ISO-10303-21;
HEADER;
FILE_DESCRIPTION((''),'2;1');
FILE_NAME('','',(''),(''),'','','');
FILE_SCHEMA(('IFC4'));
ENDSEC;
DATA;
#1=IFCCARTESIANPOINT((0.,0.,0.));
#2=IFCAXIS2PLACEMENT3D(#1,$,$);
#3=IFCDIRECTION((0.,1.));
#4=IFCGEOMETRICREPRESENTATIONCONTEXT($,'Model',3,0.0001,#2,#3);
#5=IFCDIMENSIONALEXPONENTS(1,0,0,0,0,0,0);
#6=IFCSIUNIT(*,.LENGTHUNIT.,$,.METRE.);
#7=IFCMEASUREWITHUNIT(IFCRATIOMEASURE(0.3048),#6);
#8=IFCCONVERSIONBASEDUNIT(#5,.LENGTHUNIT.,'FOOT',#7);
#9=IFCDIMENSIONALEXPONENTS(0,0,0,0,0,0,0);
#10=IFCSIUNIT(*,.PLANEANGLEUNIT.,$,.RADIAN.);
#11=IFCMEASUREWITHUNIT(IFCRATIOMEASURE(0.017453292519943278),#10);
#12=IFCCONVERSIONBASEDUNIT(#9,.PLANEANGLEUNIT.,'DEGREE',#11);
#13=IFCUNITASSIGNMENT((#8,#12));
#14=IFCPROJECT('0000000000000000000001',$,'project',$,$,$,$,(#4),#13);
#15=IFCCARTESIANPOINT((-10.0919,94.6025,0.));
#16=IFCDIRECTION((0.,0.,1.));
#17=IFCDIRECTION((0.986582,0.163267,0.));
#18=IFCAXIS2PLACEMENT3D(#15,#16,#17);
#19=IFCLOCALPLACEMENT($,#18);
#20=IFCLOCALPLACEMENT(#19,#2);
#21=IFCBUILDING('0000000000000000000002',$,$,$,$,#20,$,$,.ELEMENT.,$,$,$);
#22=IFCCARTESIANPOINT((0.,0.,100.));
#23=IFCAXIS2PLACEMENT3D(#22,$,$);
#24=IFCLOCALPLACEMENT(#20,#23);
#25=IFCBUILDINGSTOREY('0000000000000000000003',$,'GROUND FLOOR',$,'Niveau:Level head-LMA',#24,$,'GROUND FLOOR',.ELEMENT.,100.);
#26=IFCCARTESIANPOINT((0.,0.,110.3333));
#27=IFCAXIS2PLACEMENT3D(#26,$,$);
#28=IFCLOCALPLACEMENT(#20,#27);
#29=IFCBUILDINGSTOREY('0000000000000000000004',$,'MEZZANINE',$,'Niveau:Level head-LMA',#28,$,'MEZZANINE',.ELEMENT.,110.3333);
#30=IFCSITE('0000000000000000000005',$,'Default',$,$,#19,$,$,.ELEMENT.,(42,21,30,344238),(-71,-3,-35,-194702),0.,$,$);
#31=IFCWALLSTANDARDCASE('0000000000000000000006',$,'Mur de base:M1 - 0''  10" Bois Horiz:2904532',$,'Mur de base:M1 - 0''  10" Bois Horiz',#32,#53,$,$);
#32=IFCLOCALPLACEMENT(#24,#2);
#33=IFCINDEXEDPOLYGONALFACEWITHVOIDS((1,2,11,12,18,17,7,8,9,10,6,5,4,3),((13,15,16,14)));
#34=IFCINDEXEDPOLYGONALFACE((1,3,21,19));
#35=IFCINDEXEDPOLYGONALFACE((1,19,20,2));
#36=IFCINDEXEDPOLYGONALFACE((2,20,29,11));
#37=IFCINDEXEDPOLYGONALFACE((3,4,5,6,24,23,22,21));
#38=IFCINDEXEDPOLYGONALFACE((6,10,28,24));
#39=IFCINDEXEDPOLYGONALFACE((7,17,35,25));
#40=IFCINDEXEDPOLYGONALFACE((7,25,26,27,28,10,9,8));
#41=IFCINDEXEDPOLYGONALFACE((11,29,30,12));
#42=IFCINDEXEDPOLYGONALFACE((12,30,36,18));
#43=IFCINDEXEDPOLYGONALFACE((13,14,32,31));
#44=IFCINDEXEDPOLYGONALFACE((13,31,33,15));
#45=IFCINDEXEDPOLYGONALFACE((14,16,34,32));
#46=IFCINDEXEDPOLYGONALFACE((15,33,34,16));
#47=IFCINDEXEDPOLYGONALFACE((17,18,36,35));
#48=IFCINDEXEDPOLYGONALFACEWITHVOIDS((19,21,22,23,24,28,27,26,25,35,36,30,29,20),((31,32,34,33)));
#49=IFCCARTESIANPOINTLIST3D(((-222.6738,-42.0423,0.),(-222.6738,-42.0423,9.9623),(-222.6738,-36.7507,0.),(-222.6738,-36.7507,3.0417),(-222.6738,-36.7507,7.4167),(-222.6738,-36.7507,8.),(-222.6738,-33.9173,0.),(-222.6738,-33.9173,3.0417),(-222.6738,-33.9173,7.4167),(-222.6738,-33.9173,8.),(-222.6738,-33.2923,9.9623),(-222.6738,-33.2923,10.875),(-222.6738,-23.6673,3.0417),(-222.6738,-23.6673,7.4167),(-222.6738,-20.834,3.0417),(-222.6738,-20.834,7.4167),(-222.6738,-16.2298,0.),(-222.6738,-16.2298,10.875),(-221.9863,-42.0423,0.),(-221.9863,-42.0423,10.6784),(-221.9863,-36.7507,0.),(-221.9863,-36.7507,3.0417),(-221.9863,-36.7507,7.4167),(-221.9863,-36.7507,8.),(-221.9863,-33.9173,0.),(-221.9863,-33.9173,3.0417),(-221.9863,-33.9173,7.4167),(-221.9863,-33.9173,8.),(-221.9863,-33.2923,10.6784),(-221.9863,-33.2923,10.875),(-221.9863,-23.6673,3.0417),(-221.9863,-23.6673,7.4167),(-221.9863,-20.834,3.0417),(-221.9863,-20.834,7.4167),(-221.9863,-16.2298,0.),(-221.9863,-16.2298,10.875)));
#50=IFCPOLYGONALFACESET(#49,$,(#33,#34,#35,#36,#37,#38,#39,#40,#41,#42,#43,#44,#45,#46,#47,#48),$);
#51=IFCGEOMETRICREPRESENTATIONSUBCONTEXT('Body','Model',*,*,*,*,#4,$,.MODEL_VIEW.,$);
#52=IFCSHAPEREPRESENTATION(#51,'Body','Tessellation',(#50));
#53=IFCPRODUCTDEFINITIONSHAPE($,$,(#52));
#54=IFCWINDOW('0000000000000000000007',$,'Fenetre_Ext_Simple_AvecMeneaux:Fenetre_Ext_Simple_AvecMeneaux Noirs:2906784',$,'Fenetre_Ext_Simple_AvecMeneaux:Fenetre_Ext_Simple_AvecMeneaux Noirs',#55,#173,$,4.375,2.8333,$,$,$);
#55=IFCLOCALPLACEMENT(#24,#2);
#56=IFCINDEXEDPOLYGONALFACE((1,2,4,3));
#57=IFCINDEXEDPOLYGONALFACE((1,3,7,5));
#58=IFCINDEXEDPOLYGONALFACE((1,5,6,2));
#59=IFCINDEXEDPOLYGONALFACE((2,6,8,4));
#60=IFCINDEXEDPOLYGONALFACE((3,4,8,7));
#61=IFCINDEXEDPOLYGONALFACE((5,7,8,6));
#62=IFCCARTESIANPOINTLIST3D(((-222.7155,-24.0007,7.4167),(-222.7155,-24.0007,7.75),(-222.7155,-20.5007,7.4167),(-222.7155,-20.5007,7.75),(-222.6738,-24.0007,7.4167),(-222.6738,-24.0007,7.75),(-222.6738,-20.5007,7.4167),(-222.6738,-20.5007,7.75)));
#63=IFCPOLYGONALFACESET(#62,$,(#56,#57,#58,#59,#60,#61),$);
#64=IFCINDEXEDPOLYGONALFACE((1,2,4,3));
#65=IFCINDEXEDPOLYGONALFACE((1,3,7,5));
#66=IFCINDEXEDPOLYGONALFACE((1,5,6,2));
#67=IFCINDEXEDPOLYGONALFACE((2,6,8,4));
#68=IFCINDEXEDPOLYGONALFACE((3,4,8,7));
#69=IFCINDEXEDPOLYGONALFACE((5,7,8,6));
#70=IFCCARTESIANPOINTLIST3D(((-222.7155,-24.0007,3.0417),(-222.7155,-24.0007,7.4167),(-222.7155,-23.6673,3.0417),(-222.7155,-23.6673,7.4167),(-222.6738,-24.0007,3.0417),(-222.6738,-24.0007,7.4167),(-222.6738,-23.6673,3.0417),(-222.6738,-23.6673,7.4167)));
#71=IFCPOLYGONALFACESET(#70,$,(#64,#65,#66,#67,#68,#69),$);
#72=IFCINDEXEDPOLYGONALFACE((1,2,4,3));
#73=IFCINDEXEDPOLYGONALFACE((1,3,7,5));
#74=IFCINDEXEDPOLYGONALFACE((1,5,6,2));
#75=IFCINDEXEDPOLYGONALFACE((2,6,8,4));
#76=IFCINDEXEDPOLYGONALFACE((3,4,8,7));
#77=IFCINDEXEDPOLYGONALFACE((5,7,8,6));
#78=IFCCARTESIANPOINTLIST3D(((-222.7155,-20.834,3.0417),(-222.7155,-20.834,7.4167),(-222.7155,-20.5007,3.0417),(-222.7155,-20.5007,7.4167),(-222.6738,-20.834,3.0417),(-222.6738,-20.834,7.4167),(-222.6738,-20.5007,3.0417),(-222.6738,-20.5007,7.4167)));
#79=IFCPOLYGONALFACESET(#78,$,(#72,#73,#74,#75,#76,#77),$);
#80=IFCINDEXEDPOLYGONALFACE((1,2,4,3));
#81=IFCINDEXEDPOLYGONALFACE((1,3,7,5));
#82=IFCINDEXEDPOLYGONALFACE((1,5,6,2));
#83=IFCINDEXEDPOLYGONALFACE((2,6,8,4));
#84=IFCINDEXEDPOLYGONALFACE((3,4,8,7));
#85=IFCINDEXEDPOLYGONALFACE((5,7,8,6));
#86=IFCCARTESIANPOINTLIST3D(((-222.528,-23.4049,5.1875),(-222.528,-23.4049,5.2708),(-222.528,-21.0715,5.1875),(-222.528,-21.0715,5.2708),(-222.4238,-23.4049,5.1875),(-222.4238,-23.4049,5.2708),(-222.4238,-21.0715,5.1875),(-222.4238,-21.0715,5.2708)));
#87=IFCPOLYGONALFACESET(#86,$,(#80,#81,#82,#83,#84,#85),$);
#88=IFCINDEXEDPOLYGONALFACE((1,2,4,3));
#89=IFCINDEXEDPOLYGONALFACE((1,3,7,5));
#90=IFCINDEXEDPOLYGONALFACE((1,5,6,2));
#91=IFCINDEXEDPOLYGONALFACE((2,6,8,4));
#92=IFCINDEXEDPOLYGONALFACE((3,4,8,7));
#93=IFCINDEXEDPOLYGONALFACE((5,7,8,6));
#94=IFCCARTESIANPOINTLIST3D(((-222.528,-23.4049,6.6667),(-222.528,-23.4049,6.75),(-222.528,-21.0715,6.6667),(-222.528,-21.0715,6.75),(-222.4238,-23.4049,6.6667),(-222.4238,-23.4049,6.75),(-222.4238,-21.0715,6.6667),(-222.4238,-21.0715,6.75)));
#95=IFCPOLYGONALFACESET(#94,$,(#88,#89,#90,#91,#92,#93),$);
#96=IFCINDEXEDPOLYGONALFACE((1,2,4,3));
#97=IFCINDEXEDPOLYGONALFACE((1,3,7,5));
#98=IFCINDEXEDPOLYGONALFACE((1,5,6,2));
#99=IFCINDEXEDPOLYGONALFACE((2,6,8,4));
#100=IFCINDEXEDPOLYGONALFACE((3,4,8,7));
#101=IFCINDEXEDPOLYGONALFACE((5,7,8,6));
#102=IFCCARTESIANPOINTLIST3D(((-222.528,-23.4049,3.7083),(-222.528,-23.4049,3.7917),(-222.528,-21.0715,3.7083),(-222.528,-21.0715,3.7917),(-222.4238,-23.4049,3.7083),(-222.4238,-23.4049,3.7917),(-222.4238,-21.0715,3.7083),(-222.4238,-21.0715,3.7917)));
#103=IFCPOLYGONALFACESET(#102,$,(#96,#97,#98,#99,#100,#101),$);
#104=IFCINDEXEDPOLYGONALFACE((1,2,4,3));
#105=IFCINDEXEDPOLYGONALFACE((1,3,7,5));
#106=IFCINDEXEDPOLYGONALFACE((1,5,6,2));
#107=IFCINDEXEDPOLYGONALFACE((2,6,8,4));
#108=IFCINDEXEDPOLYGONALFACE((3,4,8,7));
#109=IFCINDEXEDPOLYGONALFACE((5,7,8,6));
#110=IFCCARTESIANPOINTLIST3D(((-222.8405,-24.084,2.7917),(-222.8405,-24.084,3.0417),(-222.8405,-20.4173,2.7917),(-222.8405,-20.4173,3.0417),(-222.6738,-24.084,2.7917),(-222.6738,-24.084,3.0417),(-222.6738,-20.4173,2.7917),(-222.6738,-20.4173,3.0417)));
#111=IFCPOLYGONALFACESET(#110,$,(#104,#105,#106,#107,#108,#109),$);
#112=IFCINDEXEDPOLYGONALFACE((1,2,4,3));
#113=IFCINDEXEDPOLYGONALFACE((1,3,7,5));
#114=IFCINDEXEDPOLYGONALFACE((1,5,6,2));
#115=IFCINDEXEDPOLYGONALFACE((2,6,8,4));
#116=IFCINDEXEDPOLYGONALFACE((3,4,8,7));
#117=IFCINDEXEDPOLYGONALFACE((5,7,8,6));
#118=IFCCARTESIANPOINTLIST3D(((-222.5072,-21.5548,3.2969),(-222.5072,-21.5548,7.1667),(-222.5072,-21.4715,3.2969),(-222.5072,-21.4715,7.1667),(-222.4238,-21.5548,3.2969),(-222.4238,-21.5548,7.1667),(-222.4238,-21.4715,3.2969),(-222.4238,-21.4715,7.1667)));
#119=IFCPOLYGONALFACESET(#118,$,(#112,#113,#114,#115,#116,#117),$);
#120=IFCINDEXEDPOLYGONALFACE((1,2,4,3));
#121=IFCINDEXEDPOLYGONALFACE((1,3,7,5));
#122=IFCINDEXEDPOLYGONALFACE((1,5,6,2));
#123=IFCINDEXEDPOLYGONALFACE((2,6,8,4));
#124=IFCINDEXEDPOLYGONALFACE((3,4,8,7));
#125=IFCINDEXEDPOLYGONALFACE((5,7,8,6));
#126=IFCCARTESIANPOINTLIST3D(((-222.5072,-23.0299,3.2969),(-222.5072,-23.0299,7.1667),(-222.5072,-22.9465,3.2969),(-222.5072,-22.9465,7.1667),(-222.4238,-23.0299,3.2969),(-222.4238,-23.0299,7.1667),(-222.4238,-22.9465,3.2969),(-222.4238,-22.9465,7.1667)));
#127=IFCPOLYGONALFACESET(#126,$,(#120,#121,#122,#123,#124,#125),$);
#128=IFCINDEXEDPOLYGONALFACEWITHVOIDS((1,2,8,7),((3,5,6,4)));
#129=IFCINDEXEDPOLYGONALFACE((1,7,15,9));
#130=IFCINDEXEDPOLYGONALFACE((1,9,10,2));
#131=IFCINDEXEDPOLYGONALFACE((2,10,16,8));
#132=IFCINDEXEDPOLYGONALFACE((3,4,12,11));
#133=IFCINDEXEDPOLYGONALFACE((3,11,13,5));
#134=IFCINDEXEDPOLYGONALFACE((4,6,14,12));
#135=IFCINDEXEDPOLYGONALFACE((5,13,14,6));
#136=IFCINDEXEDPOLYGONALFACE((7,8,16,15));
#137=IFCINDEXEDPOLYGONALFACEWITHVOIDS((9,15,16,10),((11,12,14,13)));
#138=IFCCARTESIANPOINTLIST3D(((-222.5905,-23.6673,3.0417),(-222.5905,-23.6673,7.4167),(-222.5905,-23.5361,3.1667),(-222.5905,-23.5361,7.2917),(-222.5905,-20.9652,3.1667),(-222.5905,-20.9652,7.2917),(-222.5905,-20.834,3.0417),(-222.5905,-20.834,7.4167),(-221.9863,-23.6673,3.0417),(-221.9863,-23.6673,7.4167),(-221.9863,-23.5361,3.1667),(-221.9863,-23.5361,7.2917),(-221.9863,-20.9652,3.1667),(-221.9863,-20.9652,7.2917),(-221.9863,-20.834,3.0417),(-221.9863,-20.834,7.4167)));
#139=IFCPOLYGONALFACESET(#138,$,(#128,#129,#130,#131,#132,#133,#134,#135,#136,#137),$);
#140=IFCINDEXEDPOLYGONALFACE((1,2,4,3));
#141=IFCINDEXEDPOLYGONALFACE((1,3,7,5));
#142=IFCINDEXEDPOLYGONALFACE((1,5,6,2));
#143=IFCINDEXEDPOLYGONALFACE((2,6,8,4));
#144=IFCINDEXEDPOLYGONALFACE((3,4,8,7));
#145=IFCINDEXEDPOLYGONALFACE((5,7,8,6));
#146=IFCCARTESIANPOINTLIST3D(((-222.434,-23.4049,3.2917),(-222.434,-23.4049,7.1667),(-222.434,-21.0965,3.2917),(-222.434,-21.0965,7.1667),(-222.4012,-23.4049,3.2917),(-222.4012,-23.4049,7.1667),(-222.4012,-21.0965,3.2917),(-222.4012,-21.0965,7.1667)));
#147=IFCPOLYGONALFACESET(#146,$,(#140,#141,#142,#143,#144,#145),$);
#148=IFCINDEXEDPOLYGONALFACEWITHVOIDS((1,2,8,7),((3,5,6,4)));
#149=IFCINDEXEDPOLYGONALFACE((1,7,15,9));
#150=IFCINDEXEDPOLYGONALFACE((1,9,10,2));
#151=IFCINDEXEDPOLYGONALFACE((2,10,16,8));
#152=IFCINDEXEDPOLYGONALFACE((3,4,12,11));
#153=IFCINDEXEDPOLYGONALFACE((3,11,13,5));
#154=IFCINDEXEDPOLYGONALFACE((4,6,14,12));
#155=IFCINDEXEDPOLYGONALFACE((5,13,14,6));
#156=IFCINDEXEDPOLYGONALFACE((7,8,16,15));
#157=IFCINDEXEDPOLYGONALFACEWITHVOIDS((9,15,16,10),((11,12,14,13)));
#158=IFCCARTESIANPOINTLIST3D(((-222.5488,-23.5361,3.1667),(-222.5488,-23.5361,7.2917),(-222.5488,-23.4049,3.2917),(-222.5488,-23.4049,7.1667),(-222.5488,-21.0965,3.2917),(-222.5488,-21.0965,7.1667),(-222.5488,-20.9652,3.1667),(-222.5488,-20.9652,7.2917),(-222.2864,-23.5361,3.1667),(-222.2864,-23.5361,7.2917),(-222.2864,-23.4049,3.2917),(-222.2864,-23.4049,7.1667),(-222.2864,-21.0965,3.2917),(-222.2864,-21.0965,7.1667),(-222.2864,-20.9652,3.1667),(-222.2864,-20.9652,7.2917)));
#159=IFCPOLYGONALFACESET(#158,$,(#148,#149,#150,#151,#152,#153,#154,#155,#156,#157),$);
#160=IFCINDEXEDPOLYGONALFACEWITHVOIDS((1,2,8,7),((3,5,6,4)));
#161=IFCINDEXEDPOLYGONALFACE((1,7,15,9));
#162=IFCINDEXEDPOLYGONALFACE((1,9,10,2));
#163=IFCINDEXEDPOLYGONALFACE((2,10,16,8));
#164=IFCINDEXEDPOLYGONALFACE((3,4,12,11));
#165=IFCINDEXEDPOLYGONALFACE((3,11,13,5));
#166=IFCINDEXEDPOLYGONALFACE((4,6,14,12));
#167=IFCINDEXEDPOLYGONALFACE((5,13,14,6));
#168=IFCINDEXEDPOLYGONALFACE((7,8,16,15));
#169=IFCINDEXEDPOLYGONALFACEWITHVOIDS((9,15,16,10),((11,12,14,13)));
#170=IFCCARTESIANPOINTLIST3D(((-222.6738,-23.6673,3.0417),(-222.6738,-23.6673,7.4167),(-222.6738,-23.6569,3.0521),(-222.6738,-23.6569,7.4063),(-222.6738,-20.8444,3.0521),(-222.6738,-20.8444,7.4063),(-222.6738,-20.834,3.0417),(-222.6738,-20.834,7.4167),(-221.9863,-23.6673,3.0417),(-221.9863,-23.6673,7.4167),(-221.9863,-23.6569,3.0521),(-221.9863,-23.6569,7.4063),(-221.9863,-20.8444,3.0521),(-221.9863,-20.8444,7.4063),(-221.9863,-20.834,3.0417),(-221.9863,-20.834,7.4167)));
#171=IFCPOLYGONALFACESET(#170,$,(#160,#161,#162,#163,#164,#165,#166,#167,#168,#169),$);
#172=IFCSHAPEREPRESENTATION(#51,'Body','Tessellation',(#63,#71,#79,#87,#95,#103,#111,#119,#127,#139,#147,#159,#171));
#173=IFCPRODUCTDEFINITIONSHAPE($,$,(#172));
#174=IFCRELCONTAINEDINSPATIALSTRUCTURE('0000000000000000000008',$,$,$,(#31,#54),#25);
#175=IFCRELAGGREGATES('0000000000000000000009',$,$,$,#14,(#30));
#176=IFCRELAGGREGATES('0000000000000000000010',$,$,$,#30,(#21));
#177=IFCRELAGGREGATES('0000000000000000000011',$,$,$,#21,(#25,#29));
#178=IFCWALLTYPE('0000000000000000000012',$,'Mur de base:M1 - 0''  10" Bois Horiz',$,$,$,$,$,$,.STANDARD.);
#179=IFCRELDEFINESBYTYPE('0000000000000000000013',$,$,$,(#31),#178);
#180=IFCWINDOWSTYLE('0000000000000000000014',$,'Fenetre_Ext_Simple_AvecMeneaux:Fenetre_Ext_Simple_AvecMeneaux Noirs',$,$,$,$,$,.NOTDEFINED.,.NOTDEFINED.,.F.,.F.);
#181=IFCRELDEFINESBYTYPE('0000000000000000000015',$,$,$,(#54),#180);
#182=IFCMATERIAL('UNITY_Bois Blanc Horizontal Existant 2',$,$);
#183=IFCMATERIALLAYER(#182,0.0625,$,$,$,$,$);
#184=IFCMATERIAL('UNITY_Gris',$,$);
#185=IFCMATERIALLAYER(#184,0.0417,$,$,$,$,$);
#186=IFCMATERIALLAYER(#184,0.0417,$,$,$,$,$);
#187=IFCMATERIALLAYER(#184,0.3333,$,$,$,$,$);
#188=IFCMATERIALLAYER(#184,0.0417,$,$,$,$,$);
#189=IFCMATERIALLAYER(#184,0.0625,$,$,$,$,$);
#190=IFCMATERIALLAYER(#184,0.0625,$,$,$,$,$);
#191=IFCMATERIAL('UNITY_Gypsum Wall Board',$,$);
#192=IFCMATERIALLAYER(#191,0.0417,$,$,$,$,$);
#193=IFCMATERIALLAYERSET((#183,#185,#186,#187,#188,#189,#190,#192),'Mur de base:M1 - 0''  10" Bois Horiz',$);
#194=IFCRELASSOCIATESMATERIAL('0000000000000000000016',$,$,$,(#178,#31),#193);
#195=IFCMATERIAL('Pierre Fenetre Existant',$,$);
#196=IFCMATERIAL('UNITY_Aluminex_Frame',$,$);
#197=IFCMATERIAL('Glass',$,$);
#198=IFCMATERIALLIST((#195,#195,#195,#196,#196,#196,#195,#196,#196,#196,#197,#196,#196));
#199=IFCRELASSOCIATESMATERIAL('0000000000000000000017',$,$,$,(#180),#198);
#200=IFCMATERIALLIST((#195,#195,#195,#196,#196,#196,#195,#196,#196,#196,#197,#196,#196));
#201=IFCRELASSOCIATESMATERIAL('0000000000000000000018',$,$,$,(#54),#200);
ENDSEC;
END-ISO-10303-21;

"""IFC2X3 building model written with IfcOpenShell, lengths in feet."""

from ifc_helpers import new_model, entity, si_unit, converted_unit, direction, frame, frame_2d, origin, origin_2d_with_axis, place, context, subcontext, project, spatial, polyline, rectangle, outline, extrude, clip, bounded_halfspace, source, transform, mapped, material, material_list, layer, layer_set, layer_usage, type_object, type_shapes, element, fill, save


model = new_model("IFC2X3")

# Units and contexts
model_context = context("Model", 3, precision=0.0001, world=origin(), true_north=direction((0.0, 1.0)))
body_context = subcontext(model_context, "Body", "Model", "MODEL_VIEW")
ifc_project = project(units=[converted_unit("LENGTHUNIT", "FOOT", entity("IfcRatioMeasure", 0.3048), si_unit("LENGTHUNIT", "METRE"), dimensions=[1, 0, 0, 0, 0, 0, 0]), converted_unit("PLANEANGLEUNIT", "DEGREE", entity("IfcRatioMeasure", 0.017453292519943278), si_unit("PLANEANGLEUNIT", "RADIAN"), dimensions=[0, 0, 0, 0, 0, 0, 0])], contexts=[model_context])

# Site, building, storey
site_placement = place(None, frame((-10.0919, 94.6025, 0.0), z_axis=(0.0, 0.0, 1.0), x_axis=(0.986582, 0.163267, 0.0)))
site = spatial("IfcSite", under=ifc_project, at=site_placement, Name="Default", CompositionType="ELEMENT", RefLatitude=(42, 21, 30, 344238), RefLongitude=(-71, -3, -35, -194702), RefElevation=0.0)
building_placement = place(site_placement, origin())
building = spatial("IfcBuilding", under=site, at=building_placement, CompositionType="ELEMENT")
storey_1_placement = place(building_placement, frame((0.0, 0.0, 100.0)))
storey_1 = spatial("IfcBuildingStorey", under=building, at=storey_1_placement, Name="GROUND FLOOR", ObjectType="Niveau:Level head-LMA", LongName="GROUND FLOOR", CompositionType="ELEMENT", Elevation=100.0)

# Shared definitions
ifc_material_1 = material(Name="UNITY_Bois Blanc Horizontal Existant 2")
ifc_layer_1 = layer(ifc_material_1, 0.0625)
ifc_material_2 = material(Name="UNITY_Gris")
ifc_layer_2 = layer(ifc_material_2, 0.0417)
ifc_layer_3 = layer(ifc_material_2, 0.0417)
ifc_layer_4 = layer(ifc_material_2, 0.3333)
ifc_layer_5 = layer(ifc_material_2, 0.0417)
ifc_layer_6 = layer(ifc_material_2, 0.0625)
ifc_layer_7 = layer(ifc_material_2, 0.0625)
ifc_material_3 = material(Name="UNITY_Gypsum Wall Board")
ifc_layer_8 = layer(ifc_material_3, 0.0417)
ifc_layer_set_1 = layer_set([ifc_layer_1, ifc_layer_2, ifc_layer_3, ifc_layer_4, ifc_layer_5, ifc_layer_6, ifc_layer_7, ifc_layer_8], Name="Mur de base:M1 - 0'  10\" Bois Horiz")
wall_type_1 = type_object("IfcWallType", Name="Mur de base:M1 - 0'  10\" Bois Horiz", PredefinedType="STANDARD", material=ifc_layer_set_1)
ifc_material_4 = material(Name="UNITY_Aluminex_Frame")
ifc_material_5 = material(Name="Glass")

# Shared definitions
storey_2_placement = place(building_placement, frame((0.0, 0.0, 110.3333)))
storey_2 = spatial("IfcBuildingStorey", under=building, at=storey_2_placement, Name="MEZZANINE", ObjectType="Niveau:Level head-LMA", LongName="MEZZANINE", CompositionType="ELEMENT", Elevation=110.3333)

# Wall, openings, window
ifc_layer_usage_1 = layer_usage(ifc_layer_set_1, "AXIS2", "NEGATIVE", 0.3438)
wall_1_placement = place(storey_1_placement, frame((-222.3301, -42.0423, 0.0), z_axis=(0.0, 0.0, 1.0), x_axis=(0.0, 1.0, 0.0)))
wall_1 = element("IfcWallStandardCase", 1, at=wall_1_placement, inside=storey_1, type_object=wall_type_1, material=ifc_layer_usage_1, Name="Mur de base:M1 - 0'  10\" Bois Horiz:2904532", ObjectType="Mur de base:M1 - 0'  10\" Bois Horiz", context=body_context, shape_type="Clipping", body=[
    clip(extrude(rectangle(XDim=25.8125, YDim=0.6875, at=frame_2d((12.9062, 0.0), x_axis=(-1.0, 0.0))), origin(), (0.0, 0.0, 1.0), 10.875), bounded_halfspace(frame((0.0, -0.3438, 10.6784), z_axis=(0.0, 0.721387, 0.692532), x_axis=(-1.0, 0.0, 0.0)), False, frame((0.0, -0.3438, 10.6784)), polyline([(0.0, 0.0), (0.6875, 0.0), (8.75, 0.0), (8.75, 0.6875), (0.0, 0.6875), (0.0, 0.0)]))),
])
opening_1_placement = place(wall_1_placement, origin())
element("IfcOpeningElement", 2, at=opening_1_placement, cuts=wall_1, ObjectType="Opening", context=body_context, shape_type="SweptSolid", body=[
    extrude(rectangle(XDim=6.2917, YDim=0.9583, at=frame_2d((0.0, 0.0), x_axis=(0.0, 1.0))), frame((25.8333, 0.1146, 15.1875), z_axis=(0.0, 1.0, 0.0), x_axis=(1.0, 0.0, 0.0)), (0.0, 0.0, 1.0), 7.3958),
])
opening_2_placement = place(wall_1_placement, origin())
element("IfcOpeningElement", 3, at=opening_2_placement, cuts=wall_1, ObjectType="Opening", context=body_context, shape_type="SweptSolid", body=[
    extrude(rectangle(XDim=6.2917, YDim=3.0, at=frame_2d((0.0, 0.0), x_axis=(0.0, 1.0))), frame((24.0833, -5.3438, 15.1875), z_axis=(0.0, 1.0, 0.0), x_axis=(-1.0, 0.0, 0.0)), (0.0, 0.0, 1.0), 10.0),
])
opening_3_placement = place(wall_1_placement, frame((42.0423, -222.3301, 0.0), z_axis=(0.0, 0.0, 1.0), x_axis=(0.0, -1.0, 0.0)))
element("IfcOpeningElement", 4, at=opening_3_placement, cuts=wall_1, ObjectType="Opening", context=body_context, shape_type="SweptSolid", body=[
    extrude(rectangle(XDim=8.0, YDim=2.8333, at=frame_2d((0.0, 0.0), x_axis=(1.0, 0.0))), frame((-217.6738, -35.334, 4.0), z_axis=(-1.0, 0.0, 0.0), x_axis=(0.0, 0.0, 1.0)), (0.0, 0.0, 1.0), 10.0),
])
opening_4_placement = place(wall_1_placement, frame((42.0423, -222.3301, 0.0), z_axis=(0.0, 0.0, 1.0), x_axis=(0.0, -1.0, 0.0)))
element("IfcOpeningElement", 5, at=opening_4_placement, cuts=wall_1, ObjectType="Opening", context=body_context, shape_type="SweptSolid", body=[
    extrude(rectangle(XDim=4.375, YDim=2.8333, at=frame_2d((0.0, 0.0), x_axis=(0.0, 1.0))), frame((-216.9863, -35.334, 5.2292), z_axis=(-1.0, 0.0, 0.0), x_axis=(0.0, -1.0, 0.0)), (0.0, 0.0, 1.0), 10.0),
])
opening_5_placement = place(wall_1_placement, frame((18.375, -0.3438, 3.0417)))
opening_5 = element("IfcOpeningElement", 6, at=opening_5_placement, cuts=wall_1, ObjectType="Opening", context=body_context, shape_type="SweptSolid", body=[
    extrude(rectangle(XDim=4.375, YDim=2.8333, at=frame_2d((2.1875, 1.4167), x_axis=(1.0, 0.0))), frame((0.0, 0.0, 0.0), z_axis=(0.0, 1.0, 0.0), x_axis=(0.0, 0.0, 1.0)), (0.0, 0.0, 1.0), 0.6875),
])
ifc_material_6 = material(Name="Pierre Fenetre Existant")
ifc_material_list_1 = material_list([ifc_material_6, ifc_material_6, ifc_material_6, ifc_material_4, ifc_material_4, ifc_material_4, ifc_material_6, ifc_material_4, ifc_material_4, ifc_material_4, ifc_material_5, ifc_material_4, ifc_material_4])
ifc_material_list_2 = material_list([ifc_material_6, ifc_material_6, ifc_material_6, ifc_material_4, ifc_material_4, ifc_material_4, ifc_material_6, ifc_material_4, ifc_material_4, ifc_material_4, ifc_material_5, ifc_material_4, ifc_material_4])
window_style_1 = type_object("IfcWindowStyle", Name="Fenetre_Ext_Simple_AvecMeneaux:Fenetre_Ext_Simple_AvecMeneaux Noirs", ConstructionType="NOTDEFINED", OperationType="NOTDEFINED", ParameterTakesPrecedence=False, Sizeable=False, material=ifc_material_list_2)
shared_shape_1 = source(origin(), body_context, "Body", "SweptSolid", [
    extrude(rectangle(XDim=3.5, YDim=0.0417, at=frame_2d((0.0, 0.0), x_axis=(1.0, 0.0))), frame((1.4167, 0.7083, 4.375)), (0.0, 0.0, 1.0), 0.3333),
    extrude(rectangle(XDim=0.3333, YDim=0.0417, at=frame_2d((0.0, 0.0), x_axis=(1.0, 0.0))), frame((-0.1667, 0.7083, 0.0)), (0.0, 0.0, 1.0), 4.375),
    extrude(rectangle(XDim=0.3333, YDim=0.0417, at=frame_2d((0.0, 0.0), x_axis=(1.0, 0.0))), frame((3.0, 0.7083, 0.0)), (0.0, 0.0, 1.0), 4.375),
    extrude(rectangle(XDim=2.3333, YDim=0.1042, at=frame_2d((0.0, 0.0), x_axis=(1.0, 0.0))), frame((1.4291, 0.4896, 2.1458), z_axis=(0.0, 0.0, 1.0), x_axis=(-1.0, 0.0, 0.0)), (0.0, 0.0, 1.0), 0.0833),
    extrude(rectangle(XDim=2.3333, YDim=0.1042, at=frame_2d((0.0, 0.0), x_axis=(1.0, 0.0))), frame((1.4291, 0.4896, 3.625), z_axis=(0.0, 0.0, 1.0), x_axis=(-1.0, 0.0, 0.0)), (0.0, 0.0, 1.0), 0.0833),
    extrude(rectangle(XDim=2.3333, YDim=0.1042, at=frame_2d((0.0, 0.0), x_axis=(1.0, 0.0))), frame((1.4291, 0.4896, 0.6667), z_axis=(0.0, 0.0, 1.0), x_axis=(-1.0, 0.0, 0.0)), (0.0, 0.0, 1.0), 0.0833),
    extrude(rectangle(XDim=3.6667, YDim=0.1667, at=frame_2d((0.0, 0.0), x_axis=(1.0, 0.0))), frame((1.4167, 0.7708, -0.25)), (0.0, 0.0, 1.0), 0.25),
    extrude(rectangle(XDim=0.0833, YDim=0.0833, at=frame_2d((0.0, 0.0), x_axis=(1.0, 0.0))), frame((2.1542, 0.4792, 0.2552), z_axis=(0.0, 0.0, 1.0), x_axis=(-1.0, 0.0, 0.0)), (0.0, 0.0, 1.0), 3.8698),
    extrude(rectangle(XDim=0.0833, YDim=0.0833, at=frame_2d((0.0, 0.0), x_axis=(1.0, 0.0))), frame((0.6791, 0.4792, 0.2552), z_axis=(0.0, 0.0, 1.0), x_axis=(-1.0, 0.0, 0.0)), (0.0, 0.0, 1.0), 3.8698),
    extrude(outline(polyline([(-2.1875, -1.4167), (2.1875, -1.4167), (2.1875, 1.4167), (-2.1875, 1.4167), (-2.1875, -1.4167)]), holes=[polyline([(-2.0625, 1.2854), (2.0625, 1.2854), (2.0625, -1.2854), (-2.0625, -1.2854), (-2.0625, 1.2854)])]), frame((1.4167, 0.6042, 2.1875), z_axis=(0.0, -1.0, 0.0), x_axis=(0.0, 0.0, -1.0)), (0.0, 0.0, 1.0), 0.6042),
    extrude(rectangle(XDim=2.3084, YDim=0.0328, at=origin_2d_with_axis()), frame((1.4167, 0.4313, 0.25)), (0.0, 0.0, 1.0), 3.875),
    extrude(outline(polyline([(-1.2854, -2.0625), (1.2854, -2.0625), (1.2854, 2.0625), (-1.2854, 2.0625), (-1.2854, -2.0625)]), holes=[polyline([(-1.1542, -1.9375), (-1.1542, 1.9375), (1.1542, 1.9375), (1.1542, -1.9375), (-1.1542, -1.9375)])]), frame((1.4167, 0.5625, 2.1875), z_axis=(0.0, -1.0, 0.0), x_axis=(-1.0, 0.0, 0.0)), (0.0, 0.0, 1.0), 0.2625),
    extrude(outline(polyline([(-2.1875, -1.4167), (2.1875, -1.4167), (2.1875, 1.4167), (-2.1875, 1.4167), (-2.1875, -1.4167)]), holes=[polyline([(-2.1771, 1.4063), (2.1771, 1.4063), (2.1771, -1.4063), (-2.1771, -1.4063), (-2.1771, 1.4063)])]), frame((1.4167, 0.6875, 2.1875), z_axis=(0.0, -1.0, 0.0), x_axis=(0.0, 0.0, -1.0)), (0.0, 0.0, 1.0), 0.6875),
])
type_shapes(window_style_1, [shared_shape_1])
window_1_placement = place(opening_5_placement, origin())
window_1 = element("IfcWindow", 7, at=window_1_placement, inside=storey_1, type_object=window_style_1, material=ifc_material_list_1, Name="Fenetre_Ext_Simple_AvecMeneaux:Fenetre_Ext_Simple_AvecMeneaux Noirs:2906784", ObjectType="Fenetre_Ext_Simple_AvecMeneaux:Fenetre_Ext_Simple_AvecMeneaux Noirs", OverallHeight=4.375, OverallWidth=2.8333, context=body_context, shape_type="MappedRepresentation", body=[
    mapped(shared_shape_1, transform((0.0, 0.0, 0.0), scale=1.0)),
])
fill(opening_5, window_1)

save(model, "model.ifc")
